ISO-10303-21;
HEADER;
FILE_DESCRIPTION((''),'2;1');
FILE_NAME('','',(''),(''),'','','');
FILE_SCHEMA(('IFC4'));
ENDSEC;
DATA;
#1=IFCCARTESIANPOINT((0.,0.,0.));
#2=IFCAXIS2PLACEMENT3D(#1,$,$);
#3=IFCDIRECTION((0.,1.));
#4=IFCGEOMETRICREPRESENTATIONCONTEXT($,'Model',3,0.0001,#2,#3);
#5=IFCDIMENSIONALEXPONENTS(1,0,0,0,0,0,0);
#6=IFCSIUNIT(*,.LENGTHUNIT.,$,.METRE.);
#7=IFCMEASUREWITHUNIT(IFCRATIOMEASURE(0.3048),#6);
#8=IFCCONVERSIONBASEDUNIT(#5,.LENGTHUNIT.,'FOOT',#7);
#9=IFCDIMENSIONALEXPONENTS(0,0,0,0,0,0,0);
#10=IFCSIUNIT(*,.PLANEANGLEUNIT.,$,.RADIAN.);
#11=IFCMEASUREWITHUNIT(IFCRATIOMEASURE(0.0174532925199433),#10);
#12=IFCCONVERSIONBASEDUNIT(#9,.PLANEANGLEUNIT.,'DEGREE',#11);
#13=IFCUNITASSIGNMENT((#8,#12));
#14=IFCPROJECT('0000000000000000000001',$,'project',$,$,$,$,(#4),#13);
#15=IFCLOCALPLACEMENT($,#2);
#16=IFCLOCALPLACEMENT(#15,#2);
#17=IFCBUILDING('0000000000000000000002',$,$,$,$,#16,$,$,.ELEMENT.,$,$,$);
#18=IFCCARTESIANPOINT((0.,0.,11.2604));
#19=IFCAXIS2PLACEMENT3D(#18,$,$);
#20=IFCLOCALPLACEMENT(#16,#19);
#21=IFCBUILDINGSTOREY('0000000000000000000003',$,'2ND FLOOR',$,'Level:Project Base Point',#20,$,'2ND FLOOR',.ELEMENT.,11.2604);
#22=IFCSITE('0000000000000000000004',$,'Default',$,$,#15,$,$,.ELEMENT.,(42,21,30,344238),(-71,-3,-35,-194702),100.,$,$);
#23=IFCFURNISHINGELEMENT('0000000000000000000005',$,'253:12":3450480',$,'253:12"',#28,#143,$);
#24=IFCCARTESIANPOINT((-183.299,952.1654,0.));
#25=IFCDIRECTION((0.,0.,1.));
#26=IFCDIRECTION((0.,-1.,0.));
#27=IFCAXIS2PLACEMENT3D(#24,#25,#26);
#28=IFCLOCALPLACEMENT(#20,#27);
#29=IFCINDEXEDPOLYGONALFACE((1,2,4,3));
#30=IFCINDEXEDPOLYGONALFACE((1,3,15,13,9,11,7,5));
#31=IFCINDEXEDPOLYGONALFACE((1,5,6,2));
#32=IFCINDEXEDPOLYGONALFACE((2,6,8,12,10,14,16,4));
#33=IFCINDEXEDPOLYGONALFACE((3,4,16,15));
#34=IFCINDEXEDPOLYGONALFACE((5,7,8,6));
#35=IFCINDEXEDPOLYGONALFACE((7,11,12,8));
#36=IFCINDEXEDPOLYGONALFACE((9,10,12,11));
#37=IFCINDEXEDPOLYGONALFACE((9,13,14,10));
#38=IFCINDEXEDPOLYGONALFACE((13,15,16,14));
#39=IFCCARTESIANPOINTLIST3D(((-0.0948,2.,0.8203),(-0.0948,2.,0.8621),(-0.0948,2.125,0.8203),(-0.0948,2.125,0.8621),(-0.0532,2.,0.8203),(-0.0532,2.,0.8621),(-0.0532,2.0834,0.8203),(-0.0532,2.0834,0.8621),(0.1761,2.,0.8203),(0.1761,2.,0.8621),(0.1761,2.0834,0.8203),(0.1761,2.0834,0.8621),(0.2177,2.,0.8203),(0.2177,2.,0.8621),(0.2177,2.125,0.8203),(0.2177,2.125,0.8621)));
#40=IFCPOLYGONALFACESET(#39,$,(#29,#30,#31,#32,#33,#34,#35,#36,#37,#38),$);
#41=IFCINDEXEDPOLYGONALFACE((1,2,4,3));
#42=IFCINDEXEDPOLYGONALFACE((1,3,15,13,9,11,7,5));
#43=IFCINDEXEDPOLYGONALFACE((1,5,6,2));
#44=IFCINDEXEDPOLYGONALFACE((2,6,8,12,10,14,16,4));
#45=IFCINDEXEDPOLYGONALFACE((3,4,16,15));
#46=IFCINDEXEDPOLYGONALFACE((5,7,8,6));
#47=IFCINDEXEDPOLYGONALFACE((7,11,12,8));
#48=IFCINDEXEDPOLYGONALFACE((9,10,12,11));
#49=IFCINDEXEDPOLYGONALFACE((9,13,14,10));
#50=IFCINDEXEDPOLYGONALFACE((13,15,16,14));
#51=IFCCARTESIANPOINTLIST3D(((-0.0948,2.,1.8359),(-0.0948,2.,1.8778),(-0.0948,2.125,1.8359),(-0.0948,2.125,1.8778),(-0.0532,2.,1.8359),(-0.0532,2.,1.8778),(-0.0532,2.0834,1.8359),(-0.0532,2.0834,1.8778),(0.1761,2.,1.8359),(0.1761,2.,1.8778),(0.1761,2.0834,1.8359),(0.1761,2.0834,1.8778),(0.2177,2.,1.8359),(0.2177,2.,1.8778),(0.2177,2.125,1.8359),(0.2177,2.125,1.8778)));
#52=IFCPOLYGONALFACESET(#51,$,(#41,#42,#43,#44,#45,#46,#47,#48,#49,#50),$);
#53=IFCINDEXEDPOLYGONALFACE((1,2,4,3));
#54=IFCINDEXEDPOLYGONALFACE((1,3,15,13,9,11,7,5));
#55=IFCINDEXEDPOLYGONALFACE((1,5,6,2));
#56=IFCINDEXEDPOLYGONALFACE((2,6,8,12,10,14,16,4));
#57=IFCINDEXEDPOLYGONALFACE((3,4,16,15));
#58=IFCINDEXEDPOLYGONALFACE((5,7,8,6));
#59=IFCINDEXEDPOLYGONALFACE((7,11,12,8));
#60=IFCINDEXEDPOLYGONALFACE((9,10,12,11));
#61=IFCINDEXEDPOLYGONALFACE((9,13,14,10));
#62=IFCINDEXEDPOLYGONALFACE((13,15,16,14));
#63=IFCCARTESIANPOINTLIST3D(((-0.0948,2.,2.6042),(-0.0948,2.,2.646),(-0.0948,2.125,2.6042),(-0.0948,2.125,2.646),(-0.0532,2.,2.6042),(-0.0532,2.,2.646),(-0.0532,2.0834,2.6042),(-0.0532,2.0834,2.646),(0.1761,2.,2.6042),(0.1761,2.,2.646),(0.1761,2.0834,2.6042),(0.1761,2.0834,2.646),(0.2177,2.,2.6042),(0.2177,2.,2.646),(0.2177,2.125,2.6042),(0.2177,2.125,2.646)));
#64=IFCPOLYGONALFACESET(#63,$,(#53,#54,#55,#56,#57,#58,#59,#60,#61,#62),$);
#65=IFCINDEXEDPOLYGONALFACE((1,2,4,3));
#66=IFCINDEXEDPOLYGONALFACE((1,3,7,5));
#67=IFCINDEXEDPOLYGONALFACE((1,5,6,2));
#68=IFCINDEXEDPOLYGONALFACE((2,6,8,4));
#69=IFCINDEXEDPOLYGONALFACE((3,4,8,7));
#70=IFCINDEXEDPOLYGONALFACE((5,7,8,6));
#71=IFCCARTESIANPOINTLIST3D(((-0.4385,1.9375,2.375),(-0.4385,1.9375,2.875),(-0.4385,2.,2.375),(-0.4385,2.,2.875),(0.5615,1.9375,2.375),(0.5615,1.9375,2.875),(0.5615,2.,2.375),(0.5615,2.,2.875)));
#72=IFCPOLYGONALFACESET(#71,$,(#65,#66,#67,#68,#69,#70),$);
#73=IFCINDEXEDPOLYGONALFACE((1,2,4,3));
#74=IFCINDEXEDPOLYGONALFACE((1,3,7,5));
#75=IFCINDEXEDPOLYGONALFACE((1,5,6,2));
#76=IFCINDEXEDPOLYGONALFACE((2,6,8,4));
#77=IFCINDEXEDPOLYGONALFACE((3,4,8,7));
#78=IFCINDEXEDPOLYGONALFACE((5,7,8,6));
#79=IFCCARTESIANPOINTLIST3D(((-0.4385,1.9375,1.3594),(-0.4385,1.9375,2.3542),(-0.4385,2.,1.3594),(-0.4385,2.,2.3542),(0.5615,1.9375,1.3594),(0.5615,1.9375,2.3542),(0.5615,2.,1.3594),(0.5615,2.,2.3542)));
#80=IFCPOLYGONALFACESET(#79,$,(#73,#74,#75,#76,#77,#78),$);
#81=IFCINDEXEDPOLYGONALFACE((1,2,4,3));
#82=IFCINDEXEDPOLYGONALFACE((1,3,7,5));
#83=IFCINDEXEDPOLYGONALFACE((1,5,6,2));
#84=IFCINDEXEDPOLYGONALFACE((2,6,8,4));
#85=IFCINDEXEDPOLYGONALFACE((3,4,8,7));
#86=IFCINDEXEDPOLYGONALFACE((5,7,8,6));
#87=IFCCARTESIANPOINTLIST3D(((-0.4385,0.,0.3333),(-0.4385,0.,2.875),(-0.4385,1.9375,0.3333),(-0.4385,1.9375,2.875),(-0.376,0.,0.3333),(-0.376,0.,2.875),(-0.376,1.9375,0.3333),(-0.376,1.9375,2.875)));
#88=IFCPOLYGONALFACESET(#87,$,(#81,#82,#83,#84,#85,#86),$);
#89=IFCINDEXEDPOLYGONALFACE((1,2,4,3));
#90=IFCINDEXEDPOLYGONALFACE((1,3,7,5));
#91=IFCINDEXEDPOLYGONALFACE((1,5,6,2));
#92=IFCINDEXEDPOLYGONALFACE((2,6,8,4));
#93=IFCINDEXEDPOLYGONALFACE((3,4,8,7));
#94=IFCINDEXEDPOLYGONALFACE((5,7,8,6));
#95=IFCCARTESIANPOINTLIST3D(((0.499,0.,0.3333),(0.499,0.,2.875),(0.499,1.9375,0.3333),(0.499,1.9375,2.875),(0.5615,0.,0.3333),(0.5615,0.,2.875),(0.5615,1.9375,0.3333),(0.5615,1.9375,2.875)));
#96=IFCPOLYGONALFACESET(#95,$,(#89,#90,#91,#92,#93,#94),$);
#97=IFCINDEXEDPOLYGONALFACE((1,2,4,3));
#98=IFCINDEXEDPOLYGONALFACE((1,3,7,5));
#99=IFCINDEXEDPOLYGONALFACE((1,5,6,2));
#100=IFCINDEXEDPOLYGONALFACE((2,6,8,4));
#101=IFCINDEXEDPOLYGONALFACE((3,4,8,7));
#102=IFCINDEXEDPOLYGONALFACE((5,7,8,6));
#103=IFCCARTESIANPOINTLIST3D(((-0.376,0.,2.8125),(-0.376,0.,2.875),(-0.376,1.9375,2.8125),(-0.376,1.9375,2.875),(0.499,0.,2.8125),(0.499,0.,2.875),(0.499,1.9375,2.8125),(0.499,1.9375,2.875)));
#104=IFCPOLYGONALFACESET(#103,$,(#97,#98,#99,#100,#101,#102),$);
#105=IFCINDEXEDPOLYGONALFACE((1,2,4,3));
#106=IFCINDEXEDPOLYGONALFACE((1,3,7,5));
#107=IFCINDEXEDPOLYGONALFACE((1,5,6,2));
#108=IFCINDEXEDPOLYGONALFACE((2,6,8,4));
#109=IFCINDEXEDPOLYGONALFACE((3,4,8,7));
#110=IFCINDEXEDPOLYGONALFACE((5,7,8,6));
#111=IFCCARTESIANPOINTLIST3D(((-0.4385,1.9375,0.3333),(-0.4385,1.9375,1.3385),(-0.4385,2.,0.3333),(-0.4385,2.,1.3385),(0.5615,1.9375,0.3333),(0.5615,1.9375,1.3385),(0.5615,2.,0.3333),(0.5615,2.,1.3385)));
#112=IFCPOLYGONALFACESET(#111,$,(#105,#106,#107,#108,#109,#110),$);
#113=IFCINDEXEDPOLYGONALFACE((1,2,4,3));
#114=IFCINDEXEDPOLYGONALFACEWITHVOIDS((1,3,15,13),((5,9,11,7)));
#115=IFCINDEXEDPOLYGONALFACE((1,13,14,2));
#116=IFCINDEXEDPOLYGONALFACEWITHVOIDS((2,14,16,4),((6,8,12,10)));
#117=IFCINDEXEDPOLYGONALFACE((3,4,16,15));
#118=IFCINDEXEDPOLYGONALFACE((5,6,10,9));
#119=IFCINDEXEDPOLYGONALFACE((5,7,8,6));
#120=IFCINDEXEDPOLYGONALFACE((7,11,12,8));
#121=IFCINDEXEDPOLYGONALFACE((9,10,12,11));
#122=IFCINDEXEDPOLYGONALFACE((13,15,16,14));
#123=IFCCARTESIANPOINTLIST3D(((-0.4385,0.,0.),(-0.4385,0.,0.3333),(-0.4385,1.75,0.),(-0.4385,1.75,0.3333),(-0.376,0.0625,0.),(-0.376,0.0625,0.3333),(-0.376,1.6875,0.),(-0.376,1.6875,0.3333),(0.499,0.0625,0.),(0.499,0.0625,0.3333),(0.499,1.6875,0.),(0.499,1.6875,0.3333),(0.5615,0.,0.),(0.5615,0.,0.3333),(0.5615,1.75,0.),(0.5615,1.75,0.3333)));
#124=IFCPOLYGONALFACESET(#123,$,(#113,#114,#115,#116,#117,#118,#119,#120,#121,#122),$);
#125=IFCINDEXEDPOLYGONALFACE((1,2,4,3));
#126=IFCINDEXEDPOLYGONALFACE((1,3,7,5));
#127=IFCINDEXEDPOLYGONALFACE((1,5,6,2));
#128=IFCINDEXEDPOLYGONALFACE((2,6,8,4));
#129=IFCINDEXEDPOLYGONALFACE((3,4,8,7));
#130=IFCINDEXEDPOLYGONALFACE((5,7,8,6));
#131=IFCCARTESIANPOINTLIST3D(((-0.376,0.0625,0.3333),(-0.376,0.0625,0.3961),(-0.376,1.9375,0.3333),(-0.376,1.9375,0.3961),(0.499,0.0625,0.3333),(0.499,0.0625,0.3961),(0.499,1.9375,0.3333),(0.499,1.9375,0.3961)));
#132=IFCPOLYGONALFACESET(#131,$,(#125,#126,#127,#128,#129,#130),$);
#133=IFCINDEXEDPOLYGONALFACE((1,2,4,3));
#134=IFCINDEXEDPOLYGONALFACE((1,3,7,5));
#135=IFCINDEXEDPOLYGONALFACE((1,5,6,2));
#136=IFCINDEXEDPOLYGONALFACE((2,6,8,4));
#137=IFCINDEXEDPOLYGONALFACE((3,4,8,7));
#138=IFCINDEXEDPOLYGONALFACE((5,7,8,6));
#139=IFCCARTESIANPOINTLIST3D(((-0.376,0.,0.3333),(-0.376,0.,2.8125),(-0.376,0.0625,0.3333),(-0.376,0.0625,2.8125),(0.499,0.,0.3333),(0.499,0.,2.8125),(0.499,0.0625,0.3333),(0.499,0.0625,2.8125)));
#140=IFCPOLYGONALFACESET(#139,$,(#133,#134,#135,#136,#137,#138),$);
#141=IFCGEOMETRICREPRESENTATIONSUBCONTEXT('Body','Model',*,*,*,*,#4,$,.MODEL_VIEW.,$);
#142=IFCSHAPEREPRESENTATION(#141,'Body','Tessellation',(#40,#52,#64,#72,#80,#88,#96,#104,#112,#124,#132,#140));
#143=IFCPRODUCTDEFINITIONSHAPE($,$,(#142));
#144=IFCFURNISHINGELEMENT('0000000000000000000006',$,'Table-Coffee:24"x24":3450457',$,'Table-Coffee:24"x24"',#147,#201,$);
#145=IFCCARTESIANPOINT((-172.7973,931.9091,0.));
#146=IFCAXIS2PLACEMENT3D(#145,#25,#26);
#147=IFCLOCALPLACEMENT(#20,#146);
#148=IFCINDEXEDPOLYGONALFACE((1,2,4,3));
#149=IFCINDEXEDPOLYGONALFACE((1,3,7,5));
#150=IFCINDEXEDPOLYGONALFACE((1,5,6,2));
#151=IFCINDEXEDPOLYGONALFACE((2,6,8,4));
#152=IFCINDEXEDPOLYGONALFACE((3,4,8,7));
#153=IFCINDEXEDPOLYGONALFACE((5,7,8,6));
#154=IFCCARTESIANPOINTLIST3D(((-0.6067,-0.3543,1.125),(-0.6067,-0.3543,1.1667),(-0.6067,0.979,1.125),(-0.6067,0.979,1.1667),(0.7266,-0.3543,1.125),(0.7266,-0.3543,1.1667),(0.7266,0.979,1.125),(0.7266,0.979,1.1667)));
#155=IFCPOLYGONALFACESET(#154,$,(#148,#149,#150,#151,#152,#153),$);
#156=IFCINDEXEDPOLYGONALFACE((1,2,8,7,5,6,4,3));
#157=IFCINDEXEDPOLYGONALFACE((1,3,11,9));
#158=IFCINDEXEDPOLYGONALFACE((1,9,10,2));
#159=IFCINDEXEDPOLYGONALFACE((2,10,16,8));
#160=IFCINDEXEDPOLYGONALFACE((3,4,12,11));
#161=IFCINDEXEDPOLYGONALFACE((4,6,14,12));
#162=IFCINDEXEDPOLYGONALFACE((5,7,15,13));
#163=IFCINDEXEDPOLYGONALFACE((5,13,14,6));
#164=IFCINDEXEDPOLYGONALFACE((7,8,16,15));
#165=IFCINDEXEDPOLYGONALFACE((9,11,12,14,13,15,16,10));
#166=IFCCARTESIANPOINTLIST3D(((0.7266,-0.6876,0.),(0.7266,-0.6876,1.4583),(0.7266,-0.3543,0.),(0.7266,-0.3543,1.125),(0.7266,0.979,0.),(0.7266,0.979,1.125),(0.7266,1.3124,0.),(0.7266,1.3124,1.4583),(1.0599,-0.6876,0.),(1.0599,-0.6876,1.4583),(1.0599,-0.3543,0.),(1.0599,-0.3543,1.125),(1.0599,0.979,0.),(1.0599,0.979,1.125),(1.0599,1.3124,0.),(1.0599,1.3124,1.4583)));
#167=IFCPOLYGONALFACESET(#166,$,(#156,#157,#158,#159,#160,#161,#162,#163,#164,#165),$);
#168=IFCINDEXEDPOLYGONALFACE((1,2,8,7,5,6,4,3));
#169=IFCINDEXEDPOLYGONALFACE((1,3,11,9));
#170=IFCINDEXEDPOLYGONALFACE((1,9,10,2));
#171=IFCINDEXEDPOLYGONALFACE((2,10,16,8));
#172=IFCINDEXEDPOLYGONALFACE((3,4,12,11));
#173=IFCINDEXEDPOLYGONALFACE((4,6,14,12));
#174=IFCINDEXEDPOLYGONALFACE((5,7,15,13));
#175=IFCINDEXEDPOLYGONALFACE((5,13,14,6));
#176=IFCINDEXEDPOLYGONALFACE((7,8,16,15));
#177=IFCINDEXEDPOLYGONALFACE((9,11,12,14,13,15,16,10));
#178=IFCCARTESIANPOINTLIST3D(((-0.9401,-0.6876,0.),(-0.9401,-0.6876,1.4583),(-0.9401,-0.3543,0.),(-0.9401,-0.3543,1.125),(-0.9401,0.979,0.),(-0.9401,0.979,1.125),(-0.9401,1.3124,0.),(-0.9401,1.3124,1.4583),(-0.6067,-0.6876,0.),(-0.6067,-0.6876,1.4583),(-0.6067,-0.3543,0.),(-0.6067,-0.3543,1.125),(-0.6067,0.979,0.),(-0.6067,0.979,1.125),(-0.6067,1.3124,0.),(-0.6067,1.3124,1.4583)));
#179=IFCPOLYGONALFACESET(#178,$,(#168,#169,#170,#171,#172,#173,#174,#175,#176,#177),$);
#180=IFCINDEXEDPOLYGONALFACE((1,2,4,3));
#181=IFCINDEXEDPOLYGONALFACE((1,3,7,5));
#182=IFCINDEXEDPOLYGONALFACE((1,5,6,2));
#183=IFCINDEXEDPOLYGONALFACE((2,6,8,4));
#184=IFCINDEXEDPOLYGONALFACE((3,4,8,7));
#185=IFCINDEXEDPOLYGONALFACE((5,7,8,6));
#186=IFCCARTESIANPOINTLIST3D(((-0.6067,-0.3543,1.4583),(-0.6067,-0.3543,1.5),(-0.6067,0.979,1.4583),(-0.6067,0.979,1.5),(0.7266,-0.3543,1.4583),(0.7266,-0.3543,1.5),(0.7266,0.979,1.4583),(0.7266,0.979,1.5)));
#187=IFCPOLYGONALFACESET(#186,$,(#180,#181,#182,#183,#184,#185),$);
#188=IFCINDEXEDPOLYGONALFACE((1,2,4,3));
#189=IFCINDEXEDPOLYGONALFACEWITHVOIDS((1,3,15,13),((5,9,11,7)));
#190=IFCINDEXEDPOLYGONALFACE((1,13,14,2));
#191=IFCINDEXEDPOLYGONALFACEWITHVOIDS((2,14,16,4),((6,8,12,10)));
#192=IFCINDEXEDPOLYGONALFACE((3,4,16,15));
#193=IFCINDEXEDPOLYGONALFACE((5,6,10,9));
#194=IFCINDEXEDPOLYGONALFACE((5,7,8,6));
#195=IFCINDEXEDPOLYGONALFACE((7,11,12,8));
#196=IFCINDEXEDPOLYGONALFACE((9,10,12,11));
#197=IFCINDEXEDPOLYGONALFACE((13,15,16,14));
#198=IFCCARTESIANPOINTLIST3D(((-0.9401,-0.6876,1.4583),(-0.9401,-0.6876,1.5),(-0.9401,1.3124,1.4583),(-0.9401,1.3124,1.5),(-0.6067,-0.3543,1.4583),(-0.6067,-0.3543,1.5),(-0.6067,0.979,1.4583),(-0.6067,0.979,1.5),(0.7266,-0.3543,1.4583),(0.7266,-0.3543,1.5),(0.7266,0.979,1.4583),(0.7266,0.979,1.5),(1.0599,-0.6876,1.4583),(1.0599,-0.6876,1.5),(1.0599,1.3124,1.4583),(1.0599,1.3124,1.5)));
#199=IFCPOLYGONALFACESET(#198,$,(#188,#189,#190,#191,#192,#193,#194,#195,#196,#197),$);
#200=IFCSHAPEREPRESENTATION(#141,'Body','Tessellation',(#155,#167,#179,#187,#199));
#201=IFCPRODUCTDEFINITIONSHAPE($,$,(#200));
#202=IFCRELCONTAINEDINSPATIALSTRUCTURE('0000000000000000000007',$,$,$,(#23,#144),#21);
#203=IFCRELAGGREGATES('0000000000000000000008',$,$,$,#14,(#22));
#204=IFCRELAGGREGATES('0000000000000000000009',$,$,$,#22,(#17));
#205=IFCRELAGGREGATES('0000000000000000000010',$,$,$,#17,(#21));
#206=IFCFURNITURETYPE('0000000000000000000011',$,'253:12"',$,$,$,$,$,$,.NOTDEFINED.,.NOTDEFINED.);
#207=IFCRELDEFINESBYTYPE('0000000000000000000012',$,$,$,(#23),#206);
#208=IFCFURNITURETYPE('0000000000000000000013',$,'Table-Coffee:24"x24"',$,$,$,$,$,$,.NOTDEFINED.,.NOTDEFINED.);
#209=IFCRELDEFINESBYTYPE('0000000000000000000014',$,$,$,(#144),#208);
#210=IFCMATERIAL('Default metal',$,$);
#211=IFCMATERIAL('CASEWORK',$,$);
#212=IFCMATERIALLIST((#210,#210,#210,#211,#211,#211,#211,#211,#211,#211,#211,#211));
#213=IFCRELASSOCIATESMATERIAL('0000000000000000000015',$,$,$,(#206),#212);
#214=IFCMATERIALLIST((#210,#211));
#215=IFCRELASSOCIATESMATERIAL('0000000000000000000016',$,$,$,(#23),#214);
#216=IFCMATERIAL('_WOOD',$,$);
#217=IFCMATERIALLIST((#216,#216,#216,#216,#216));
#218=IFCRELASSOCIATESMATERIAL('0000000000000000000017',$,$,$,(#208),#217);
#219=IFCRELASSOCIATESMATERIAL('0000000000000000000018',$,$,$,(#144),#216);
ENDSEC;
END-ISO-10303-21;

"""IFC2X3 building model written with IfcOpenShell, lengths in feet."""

from ifc_helpers import new_model, entity, si_unit, converted_unit, direction, frame, frame_2d, origin, origin_2d_with_axis, place, context, subcontext, project, spatial, polyline, rectangle, outline, extrude, source, transform, mapped, material, material_list, type_object, type_shapes, element, save


model = new_model("IFC2X3")

# Units and contexts
model_context = context("Model", 3, precision=0.0001, world=origin(), true_north=direction((0.0, 1.0)))
body_context = subcontext(model_context, "Body", "Model", "MODEL_VIEW")
ifc_project = project(units=[converted_unit("LENGTHUNIT", "FOOT", entity("IfcRatioMeasure", 0.3048), si_unit("LENGTHUNIT", "METRE"), dimensions=[1, 0, 0, 0, 0, 0, 0]), converted_unit("PLANEANGLEUNIT", "DEGREE", entity("IfcRatioMeasure", 0.0174532925199433), si_unit("PLANEANGLEUNIT", "RADIAN"), dimensions=[0, 0, 0, 0, 0, 0, 0])], contexts=[model_context])

# Site, building, storey
site_placement = place(None, origin())
site = spatial("IfcSite", under=ifc_project, at=site_placement, Name="Default", CompositionType="ELEMENT", RefLatitude=(42, 21, 30, 344238), RefLongitude=(-71, -3, -35, -194702), RefElevation=100.0)
building_placement = place(site_placement, origin())
building = spatial("IfcBuilding", under=site, at=building_placement, CompositionType="ELEMENT")
storey_placement = place(building_placement, frame((0.0, 0.0, 11.2604)))
storey = spatial("IfcBuildingStorey", under=building, at=storey_placement, Name="2ND FLOOR", ObjectType="Level:Project Base Point", LongName="2ND FLOOR", CompositionType="ELEMENT", Elevation=11.2604)

# Furnishing elements
ifc_material_1 = material(Name="Default metal")
ifc_material_2 = material(Name="CASEWORK")
ifc_material_list_1 = material_list([ifc_material_1, ifc_material_1, ifc_material_1, ifc_material_2, ifc_material_2, ifc_material_2, ifc_material_2, ifc_material_2, ifc_material_2, ifc_material_2, ifc_material_2, ifc_material_2])
furniture_type_1 = type_object("IfcFurnitureType", Name="253:12\"", material=ifc_material_list_1)
shared_shape_1 = source(origin(), body_context, "Body", "SweptSolid", [
    extrude(outline(polyline([(-0.1562, -0.0521), (-0.1146, -0.0521), (-0.1146, 0.0313), (0.1146, 0.0313), (0.1146, -0.0521), (0.1562, -0.0521), (0.1562, 0.0729), (-0.1562, 0.0729), (-0.1562, -0.0521)])), frame((0.0615, 2.0521, 0.8203)), (0.0, 0.0, 1.0), 0.0418),
    extrude(outline(polyline([(-0.1562, -0.0521), (-0.1146, -0.0521), (-0.1146, 0.0313), (0.1146, 0.0313), (0.1146, -0.0521), (0.1562, -0.0521), (0.1562, 0.0729), (-0.1562, 0.0729), (-0.1562, -0.0521)])), frame((0.0615, 2.0521, 1.8359)), (0.0, 0.0, 1.0), 0.0418),
    extrude(outline(polyline([(-0.1562, -0.0521), (-0.1146, -0.0521), (-0.1146, 0.0313), (0.1146, 0.0313), (0.1146, -0.0521), (0.1562, -0.0521), (0.1562, 0.0729), (-0.1562, 0.0729), (-0.1562, -0.0521)])), frame((0.0615, 2.0521, 2.6042)), (0.0, 0.0, 1.0), 0.0418),
    extrude(rectangle(XDim=1.0, YDim=0.0625, at=frame_2d((0.0, 0.0), x_axis=(1.0, 0.0))), frame((0.0615, 1.9688, 2.375), z_axis=(0.0, 0.0, 1.0), x_axis=(-1.0, 0.0, 0.0)), (0.0, 0.0, 1.0), 0.5),
    extrude(rectangle(XDim=1.0, YDim=0.0625, at=frame_2d((0.0, 0.0), x_axis=(1.0, 0.0))), frame((0.0615, 1.9688, 1.3594), z_axis=(0.0, 0.0, 1.0), x_axis=(-1.0, 0.0, 0.0)), (0.0, 0.0, 1.0), 0.9948),
    extrude(rectangle(XDim=1.9375, YDim=0.0625, at=frame_2d((0.0, 0.0), x_axis=(1.0, 0.0))), frame((-0.4073, 0.9687, 0.3333), z_axis=(0.0, 0.0, 1.0), x_axis=(0.0, -1.0, 0.0)), (0.0, 0.0, 1.0), 2.5417),
    extrude(rectangle(XDim=1.9375, YDim=0.0625, at=frame_2d((0.0, 0.0), x_axis=(1.0, 0.0))), frame((0.5302, 0.9687, 0.3333), z_axis=(0.0, 0.0, 1.0), x_axis=(0.0, -1.0, 0.0)), (0.0, 0.0, 1.0), 2.5417),
    extrude(rectangle(XDim=1.9375, YDim=0.875, at=origin_2d_with_axis()), frame((0.0615, 0.9688, 2.8125), z_axis=(0.0, 0.0, 1.0), x_axis=(0.0, 1.0, 0.0)), (0.0, 0.0, 1.0), 0.0625),
    extrude(rectangle(XDim=1.0, YDim=0.0625, at=frame_2d((0.0, 0.0), x_axis=(1.0, 0.0))), frame((0.0615, 1.9688, 0.3333), z_axis=(0.0, 0.0, 1.0), x_axis=(-1.0, 0.0, 0.0)), (0.0, 0.0, 1.0), 1.0052),
    extrude(outline(polyline([(-0.875, -0.5), (0.875, -0.5), (0.875, 0.5), (-0.875, 0.5), (-0.875, -0.5)]), holes=[polyline([(-0.8125, -0.4375), (-0.8125, 0.4375), (0.8125, 0.4375), (0.8125, -0.4375), (-0.8125, -0.4375)])]), frame((0.0615, 0.875, 0.0), z_axis=(0.0, 0.0, 1.0), x_axis=(0.0, -1.0, 0.0)), (0.0, 0.0, 1.0), 0.3333),
    extrude(rectangle(XDim=1.875, YDim=0.875, at=origin_2d_with_axis()), frame((0.0615, 1.0, 0.3333), z_axis=(0.0, 0.0, 1.0), x_axis=(0.0, 1.0, 0.0)), (0.0, 0.0, 1.0), 0.0627),
    extrude(rectangle(XDim=0.875, YDim=0.0625, at=origin_2d_with_axis()), frame((0.0615, 0.0312, 0.3333), z_axis=(0.0, 0.0, 1.0), x_axis=(-1.0, 0.0, 0.0)), (0.0, 0.0, 1.0), 2.4792),
])
type_shapes(furniture_type_1, [shared_shape_1])
ifc_material_list_2 = material_list([ifc_material_1, ifc_material_2])
furnishing_1_placement = place(storey_placement, frame((-183.299, 952.1654, 0.0), z_axis=(0.0, 0.0, 1.0), x_axis=(0.0, -1.0, 0.0)))
element("IfcFurnishingElement", 1, at=furnishing_1_placement, inside=storey, type_object=furniture_type_1, material=ifc_material_list_2, Name="253:12\":3450480", ObjectType="253:12\"", context=body_context, shape_type="MappedRepresentation", body=[
    mapped(shared_shape_1, transform((0.0, 0.0, 0.0), scale=1.0)),
])
ifc_material_3 = material(Name="_WOOD")
ifc_material_list_3 = material_list([ifc_material_3, ifc_material_3, ifc_material_3, ifc_material_3, ifc_material_3])
furniture_type_2 = type_object("IfcFurnitureType", Name="Table-Coffee:24\"x24\"", material=ifc_material_list_3)
shared_shape_2 = source(origin(), body_context, "Body", "SweptSolid", [
    extrude(rectangle(XDim=1.3333, YDim=1.3333, at=origin_2d_with_axis()), frame((0.0599, 0.3124, 1.125), z_axis=(0.0, 0.0, 1.0), x_axis=(-1.0, 0.0, 0.0)), (0.0, 0.0, 1.0), 0.0417),
    extrude(outline(polyline([(-0.6458, -1.0), (0.8125, -1.0), (0.8125, 1.0), (-0.6458, 1.0), (-0.6458, 0.6667), (0.4792, 0.6667), (0.4792, -0.6667), (-0.6458, -0.6667), (-0.6458, -1.0)])), frame((0.7266, 0.3124, 0.6458), z_axis=(1.0, 0.0, 0.0), x_axis=(0.0, 0.0, 1.0)), (0.0, 0.0, 1.0), 0.3333),
    extrude(outline(polyline([(-1.0, -0.8125), (1.0, -0.8125), (1.0, 0.6458), (0.6667, 0.6458), (0.6667, -0.4792), (-0.6667, -0.4792), (-0.6667, 0.6458), (-1.0, 0.6458), (-1.0, -0.8125)])), frame((-0.9401, 0.3124, 0.6458), z_axis=(1.0, 0.0, 0.0), x_axis=(0.0, -1.0, 0.0)), (0.0, 0.0, 1.0), 0.3333),
    extrude(rectangle(XDim=1.3333, YDim=1.3333, at=origin_2d_with_axis()), frame((0.0599, 0.3124, 1.4583), z_axis=(0.0, 0.0, 1.0), x_axis=(-1.0, 0.0, 0.0)), (0.0, 0.0, 1.0), 0.0417),
    extrude(outline(polyline([(-1.0, -1.0), (1.0, -1.0), (1.0, 1.0), (-1.0, 1.0), (-1.0, -1.0)]), holes=[polyline([(-0.6667, -0.6667), (-0.6667, 0.6667), (0.6667, 0.6667), (0.6667, -0.6667), (-0.6667, -0.6667)])]), frame((0.0599, 0.3124, 1.4583), z_axis=(0.0, 0.0, 1.0), x_axis=(-1.0, 0.0, 0.0)), (0.0, 0.0, 1.0), 0.0417),
])
type_shapes(furniture_type_2, [shared_shape_2])
furnishing_2_placement = place(storey_placement, frame((-172.7973, 931.9091, 0.0), z_axis=(0.0, 0.0, 1.0), x_axis=(0.0, -1.0, 0.0)))
element("IfcFurnishingElement", 2, at=furnishing_2_placement, inside=storey, type_object=furniture_type_2, material=ifc_material_3, Name="Table-Coffee:24\"x24\":3450457", ObjectType="Table-Coffee:24\"x24\"", context=body_context, shape_type="MappedRepresentation", body=[
    mapped(shared_shape_2, transform((0.0, 0.0, 0.0), scale=1.0)),
])

save(model, "model.ifc")
